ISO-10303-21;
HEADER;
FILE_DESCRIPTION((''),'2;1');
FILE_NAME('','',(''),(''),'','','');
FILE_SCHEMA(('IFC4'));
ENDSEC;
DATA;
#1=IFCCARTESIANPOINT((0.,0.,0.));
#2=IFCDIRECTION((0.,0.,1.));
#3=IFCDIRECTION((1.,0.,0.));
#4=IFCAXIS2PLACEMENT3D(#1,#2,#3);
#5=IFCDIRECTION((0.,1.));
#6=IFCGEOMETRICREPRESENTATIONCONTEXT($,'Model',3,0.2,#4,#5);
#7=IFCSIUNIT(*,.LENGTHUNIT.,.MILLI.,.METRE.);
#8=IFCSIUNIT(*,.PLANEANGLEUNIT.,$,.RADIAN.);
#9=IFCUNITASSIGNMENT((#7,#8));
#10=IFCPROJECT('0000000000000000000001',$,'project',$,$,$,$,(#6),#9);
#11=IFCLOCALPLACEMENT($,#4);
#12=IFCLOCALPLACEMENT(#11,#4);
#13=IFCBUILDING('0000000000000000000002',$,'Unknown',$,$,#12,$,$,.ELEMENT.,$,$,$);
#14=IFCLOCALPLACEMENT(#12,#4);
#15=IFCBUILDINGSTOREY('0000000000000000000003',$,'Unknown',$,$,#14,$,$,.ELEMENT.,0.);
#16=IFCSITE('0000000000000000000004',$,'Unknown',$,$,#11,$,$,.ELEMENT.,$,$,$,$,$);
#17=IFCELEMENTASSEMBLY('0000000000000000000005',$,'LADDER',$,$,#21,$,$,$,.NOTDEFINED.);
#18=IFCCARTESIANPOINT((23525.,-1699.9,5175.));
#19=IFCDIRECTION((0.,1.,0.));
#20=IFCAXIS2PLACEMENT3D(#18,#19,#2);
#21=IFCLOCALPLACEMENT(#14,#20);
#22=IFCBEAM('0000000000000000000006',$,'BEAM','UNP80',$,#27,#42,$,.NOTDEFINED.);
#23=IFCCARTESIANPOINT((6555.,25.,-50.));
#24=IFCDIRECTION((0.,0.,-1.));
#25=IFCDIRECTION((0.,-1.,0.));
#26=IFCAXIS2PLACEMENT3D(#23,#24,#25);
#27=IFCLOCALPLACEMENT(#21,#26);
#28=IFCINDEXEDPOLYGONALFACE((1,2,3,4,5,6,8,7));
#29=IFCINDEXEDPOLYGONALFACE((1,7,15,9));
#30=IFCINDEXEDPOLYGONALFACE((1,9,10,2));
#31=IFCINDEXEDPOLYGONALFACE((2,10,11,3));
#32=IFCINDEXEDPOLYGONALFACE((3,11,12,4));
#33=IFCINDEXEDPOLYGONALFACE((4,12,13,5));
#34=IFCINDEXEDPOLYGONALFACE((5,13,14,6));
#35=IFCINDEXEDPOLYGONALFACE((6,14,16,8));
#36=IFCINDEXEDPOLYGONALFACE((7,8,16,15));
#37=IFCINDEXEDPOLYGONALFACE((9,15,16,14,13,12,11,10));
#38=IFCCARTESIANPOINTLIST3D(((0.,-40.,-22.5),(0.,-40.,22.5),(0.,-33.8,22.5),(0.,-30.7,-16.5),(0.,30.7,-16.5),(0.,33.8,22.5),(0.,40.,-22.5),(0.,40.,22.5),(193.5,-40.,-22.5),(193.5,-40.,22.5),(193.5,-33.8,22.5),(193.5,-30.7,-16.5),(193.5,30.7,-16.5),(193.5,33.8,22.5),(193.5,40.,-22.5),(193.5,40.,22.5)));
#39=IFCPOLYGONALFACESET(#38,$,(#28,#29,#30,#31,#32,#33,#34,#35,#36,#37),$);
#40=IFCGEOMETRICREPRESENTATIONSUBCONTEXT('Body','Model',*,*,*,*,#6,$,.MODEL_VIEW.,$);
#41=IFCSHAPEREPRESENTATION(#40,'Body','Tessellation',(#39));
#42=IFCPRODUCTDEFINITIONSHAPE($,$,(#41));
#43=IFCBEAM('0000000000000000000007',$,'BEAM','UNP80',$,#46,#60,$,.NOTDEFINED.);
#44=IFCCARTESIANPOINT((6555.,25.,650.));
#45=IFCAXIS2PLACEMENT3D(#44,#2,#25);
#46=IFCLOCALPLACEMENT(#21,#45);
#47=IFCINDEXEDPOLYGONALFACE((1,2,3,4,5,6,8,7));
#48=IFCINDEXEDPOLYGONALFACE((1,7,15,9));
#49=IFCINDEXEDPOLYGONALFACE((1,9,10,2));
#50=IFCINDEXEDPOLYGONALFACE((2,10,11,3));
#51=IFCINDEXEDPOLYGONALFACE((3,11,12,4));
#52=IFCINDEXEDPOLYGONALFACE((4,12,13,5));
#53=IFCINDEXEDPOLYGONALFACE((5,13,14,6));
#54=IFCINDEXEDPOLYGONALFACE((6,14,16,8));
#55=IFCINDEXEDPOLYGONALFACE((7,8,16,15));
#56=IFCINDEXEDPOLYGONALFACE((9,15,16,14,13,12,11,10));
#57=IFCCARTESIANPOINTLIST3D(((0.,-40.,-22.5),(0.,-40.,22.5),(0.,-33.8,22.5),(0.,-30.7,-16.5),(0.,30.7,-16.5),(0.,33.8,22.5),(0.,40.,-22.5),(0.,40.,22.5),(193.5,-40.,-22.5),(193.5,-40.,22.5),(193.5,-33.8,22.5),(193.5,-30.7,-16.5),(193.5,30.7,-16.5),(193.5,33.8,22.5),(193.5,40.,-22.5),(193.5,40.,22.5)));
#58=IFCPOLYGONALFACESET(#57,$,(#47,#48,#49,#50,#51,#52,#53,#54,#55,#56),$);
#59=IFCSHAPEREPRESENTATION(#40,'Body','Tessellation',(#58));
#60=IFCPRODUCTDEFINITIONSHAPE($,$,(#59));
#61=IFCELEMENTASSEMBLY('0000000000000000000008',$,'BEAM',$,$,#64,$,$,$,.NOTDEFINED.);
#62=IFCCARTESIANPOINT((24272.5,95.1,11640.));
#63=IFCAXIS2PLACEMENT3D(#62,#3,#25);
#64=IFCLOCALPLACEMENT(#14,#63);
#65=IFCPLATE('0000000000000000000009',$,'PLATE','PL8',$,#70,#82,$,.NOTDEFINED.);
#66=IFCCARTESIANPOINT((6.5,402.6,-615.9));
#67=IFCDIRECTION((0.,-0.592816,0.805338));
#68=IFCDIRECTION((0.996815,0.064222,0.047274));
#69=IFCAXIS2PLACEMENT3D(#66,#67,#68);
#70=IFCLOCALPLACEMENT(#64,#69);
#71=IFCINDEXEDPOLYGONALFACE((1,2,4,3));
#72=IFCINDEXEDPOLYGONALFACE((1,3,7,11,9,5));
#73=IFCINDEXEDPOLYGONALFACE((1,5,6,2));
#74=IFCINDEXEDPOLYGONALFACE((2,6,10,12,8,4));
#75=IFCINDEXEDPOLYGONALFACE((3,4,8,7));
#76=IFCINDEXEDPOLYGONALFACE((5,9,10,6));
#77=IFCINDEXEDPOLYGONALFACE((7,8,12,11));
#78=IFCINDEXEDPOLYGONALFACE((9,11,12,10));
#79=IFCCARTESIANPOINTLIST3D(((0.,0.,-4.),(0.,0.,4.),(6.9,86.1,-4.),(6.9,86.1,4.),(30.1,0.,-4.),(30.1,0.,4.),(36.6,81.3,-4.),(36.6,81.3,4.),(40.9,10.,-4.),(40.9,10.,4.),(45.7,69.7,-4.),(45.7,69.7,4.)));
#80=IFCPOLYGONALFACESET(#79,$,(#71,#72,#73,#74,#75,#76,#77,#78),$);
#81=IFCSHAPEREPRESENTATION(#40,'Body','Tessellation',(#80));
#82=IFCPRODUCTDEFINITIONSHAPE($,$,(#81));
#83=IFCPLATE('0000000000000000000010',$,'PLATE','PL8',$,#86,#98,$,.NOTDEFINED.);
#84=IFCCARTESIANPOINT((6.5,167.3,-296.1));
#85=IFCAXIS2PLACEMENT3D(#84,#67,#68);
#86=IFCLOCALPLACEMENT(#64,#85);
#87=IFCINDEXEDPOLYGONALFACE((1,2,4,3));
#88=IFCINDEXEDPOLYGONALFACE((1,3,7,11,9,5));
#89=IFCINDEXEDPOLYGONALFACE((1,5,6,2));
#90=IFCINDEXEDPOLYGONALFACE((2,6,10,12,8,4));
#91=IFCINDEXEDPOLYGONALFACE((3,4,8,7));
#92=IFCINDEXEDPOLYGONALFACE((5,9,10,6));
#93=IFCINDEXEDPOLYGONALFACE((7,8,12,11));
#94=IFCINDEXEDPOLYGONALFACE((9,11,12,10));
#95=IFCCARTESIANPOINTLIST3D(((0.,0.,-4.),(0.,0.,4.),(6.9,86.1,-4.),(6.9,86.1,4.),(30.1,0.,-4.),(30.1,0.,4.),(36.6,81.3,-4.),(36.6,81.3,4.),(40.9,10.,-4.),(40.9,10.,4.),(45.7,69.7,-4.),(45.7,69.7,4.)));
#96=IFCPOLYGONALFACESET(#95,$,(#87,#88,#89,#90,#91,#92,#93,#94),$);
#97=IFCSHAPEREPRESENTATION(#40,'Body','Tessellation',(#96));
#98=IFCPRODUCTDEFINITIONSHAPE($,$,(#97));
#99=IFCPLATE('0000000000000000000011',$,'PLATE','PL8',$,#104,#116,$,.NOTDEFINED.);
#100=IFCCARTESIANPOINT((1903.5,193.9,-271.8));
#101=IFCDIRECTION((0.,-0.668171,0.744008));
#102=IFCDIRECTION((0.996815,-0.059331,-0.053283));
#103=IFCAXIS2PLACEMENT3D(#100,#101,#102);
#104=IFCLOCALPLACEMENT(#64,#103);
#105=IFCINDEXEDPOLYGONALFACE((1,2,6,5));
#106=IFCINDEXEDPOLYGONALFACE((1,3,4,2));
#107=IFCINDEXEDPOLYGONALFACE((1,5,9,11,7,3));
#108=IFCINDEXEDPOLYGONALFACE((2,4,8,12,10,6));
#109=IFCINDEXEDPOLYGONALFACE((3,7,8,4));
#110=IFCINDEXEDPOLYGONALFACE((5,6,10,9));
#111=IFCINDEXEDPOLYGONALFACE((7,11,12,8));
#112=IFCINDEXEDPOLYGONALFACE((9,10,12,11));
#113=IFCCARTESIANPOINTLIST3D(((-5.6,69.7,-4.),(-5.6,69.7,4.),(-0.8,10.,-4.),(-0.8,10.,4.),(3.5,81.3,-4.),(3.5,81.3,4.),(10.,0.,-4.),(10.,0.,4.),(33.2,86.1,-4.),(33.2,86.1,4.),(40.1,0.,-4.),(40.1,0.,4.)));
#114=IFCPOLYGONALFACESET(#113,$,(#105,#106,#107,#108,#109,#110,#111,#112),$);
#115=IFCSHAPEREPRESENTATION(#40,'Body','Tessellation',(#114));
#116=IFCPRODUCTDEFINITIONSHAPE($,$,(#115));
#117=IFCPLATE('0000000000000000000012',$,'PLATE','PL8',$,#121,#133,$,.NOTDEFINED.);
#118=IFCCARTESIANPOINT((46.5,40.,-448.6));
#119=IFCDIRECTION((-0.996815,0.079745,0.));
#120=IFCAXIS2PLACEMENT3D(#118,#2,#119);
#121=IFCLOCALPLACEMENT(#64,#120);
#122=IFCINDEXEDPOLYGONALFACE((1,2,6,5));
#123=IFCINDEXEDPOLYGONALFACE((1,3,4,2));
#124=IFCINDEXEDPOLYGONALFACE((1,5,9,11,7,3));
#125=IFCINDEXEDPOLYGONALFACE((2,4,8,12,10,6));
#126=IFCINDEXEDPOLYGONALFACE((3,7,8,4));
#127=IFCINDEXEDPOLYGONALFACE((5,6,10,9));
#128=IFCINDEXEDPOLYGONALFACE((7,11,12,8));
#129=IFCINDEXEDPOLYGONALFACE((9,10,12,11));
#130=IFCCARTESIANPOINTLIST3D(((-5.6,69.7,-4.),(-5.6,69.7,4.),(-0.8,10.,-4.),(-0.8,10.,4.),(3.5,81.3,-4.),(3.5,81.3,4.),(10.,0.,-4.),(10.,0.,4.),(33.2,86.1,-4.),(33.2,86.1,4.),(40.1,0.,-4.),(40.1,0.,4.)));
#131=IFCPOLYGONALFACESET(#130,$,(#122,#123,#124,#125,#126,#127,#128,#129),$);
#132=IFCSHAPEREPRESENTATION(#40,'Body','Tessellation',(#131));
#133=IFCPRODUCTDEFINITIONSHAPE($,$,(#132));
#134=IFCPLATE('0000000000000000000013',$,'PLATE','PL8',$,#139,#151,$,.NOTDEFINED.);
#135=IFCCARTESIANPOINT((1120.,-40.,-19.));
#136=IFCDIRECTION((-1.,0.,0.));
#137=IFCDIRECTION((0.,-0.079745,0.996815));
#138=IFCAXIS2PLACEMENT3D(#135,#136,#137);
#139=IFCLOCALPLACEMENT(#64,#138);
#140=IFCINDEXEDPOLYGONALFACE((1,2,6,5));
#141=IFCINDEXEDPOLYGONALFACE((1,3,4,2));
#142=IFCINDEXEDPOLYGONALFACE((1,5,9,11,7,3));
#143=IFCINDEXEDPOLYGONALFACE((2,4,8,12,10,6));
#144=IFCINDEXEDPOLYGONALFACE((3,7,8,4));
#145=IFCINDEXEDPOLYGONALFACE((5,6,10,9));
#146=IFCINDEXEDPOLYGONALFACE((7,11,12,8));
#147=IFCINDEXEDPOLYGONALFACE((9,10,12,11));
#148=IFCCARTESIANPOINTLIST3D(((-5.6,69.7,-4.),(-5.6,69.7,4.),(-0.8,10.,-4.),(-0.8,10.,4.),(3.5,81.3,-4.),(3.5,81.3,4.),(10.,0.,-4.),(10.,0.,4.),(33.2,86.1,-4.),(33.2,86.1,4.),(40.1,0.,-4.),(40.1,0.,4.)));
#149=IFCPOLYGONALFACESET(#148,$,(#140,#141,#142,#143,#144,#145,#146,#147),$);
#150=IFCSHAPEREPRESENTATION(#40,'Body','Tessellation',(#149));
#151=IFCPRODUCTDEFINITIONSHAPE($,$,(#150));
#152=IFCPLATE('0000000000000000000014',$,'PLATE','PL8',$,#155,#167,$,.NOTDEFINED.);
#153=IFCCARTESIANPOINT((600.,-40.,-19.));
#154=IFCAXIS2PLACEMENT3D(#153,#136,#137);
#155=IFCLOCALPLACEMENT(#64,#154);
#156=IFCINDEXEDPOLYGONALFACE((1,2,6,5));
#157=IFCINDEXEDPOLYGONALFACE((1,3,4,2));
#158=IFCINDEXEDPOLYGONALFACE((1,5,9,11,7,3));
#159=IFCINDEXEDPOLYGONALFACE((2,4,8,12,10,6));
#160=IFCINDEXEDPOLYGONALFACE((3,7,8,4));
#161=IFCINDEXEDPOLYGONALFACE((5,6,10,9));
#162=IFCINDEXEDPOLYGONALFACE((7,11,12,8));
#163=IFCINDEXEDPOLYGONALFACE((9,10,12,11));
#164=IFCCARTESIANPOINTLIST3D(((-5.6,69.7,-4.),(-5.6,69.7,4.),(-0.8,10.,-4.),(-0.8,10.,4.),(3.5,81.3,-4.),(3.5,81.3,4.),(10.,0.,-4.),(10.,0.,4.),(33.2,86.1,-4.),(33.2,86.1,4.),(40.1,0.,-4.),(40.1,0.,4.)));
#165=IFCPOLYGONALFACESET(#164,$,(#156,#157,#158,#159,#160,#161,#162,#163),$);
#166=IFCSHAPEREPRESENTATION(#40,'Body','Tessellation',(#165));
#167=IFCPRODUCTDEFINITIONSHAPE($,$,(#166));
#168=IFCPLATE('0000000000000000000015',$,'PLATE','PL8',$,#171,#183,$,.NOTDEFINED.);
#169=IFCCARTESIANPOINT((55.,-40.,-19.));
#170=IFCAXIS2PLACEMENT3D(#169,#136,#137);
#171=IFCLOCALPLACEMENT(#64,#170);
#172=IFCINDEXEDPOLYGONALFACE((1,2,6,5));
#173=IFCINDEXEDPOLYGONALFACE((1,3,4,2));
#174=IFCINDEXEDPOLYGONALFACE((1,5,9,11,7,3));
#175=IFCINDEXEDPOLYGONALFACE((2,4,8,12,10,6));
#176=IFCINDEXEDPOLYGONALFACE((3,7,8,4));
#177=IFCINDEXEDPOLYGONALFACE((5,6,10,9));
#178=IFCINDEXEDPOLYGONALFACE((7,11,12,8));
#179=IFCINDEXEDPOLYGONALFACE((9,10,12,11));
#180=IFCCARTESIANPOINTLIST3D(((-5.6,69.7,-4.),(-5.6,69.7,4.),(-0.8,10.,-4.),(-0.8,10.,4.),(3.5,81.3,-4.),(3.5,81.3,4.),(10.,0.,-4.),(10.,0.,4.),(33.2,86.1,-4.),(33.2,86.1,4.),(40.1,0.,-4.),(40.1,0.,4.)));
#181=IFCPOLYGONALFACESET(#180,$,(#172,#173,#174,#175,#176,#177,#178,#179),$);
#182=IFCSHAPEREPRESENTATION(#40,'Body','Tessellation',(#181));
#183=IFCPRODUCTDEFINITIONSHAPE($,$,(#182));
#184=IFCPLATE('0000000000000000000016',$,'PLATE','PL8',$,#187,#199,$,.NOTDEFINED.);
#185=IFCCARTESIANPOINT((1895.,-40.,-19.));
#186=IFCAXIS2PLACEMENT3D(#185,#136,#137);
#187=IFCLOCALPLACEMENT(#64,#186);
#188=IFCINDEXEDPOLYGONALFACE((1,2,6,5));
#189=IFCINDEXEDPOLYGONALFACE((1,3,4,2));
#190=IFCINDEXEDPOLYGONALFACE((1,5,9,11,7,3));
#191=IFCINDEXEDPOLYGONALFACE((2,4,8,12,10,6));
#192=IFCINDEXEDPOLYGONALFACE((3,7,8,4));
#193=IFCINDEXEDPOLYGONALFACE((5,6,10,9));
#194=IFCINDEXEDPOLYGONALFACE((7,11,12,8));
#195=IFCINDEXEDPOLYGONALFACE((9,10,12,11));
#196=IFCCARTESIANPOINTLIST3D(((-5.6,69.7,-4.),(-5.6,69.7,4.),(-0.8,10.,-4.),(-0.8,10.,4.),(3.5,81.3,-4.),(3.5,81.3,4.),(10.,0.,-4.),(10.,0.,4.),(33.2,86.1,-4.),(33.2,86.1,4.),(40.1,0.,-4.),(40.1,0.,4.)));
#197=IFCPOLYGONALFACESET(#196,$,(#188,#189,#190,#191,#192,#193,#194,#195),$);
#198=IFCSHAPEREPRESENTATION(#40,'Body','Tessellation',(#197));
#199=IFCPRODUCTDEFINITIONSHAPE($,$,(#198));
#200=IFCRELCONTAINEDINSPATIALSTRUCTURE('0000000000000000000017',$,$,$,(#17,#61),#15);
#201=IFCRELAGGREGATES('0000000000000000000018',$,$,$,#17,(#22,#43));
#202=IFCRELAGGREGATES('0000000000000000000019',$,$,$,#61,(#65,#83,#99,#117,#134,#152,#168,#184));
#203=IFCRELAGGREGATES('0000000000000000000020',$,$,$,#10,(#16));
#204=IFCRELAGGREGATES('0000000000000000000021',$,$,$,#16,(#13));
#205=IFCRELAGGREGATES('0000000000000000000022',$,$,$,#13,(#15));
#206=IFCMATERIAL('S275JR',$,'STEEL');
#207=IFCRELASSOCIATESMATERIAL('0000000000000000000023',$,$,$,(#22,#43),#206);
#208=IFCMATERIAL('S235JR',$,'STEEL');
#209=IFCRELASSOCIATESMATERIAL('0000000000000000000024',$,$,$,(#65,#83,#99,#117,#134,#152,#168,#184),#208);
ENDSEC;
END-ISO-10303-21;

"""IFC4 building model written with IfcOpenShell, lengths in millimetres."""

from ifc_helpers import new_model, si_unit, direction, frame, origin_with_axes, place, context, subcontext, project, spatial, line, indexed_curve, outline, extrude, material, element, aggregate, save


model = new_model("IFC4")

# Units and contexts
model_context = context("Model", 3, precision=0.2, world=origin_with_axes(), true_north=direction((0.0, 1.0)))
body_context = subcontext(model_context, "Body", "Model", "MODEL_VIEW")
ifc_project = project(units=[si_unit("LENGTHUNIT", "METRE", prefix="MILLI"), si_unit("PLANEANGLEUNIT", "RADIAN")], contexts=[model_context])

# Site, building, storey
site_placement = place(None, origin_with_axes())
site = spatial("IfcSite", under=ifc_project, at=site_placement, Name="Unknown", CompositionType="ELEMENT")
building_placement = place(site_placement, origin_with_axes())
building = spatial("IfcBuilding", under=site, at=building_placement, Name="Unknown", CompositionType="ELEMENT")
storey_placement = place(building_placement, origin_with_axes())
storey = spatial("IfcBuildingStorey", under=building, at=storey_placement, Name="Unknown", CompositionType="ELEMENT", Elevation=0.0)

# Element assembly, beams
assembly_1_placement = place(storey_placement, frame((23525.0, -1699.9, 5175.0), z_axis=(0.0, 1.0, 0.0), x_axis=(0.0, 0.0, 1.0)))
assembly_1 = element("IfcElementAssembly", 1, at=assembly_1_placement, inside=storey, Name="LADDER", PredefinedType="NOTDEFINED")
ifc_material_1 = material(Name="S235JR", Category="STEEL")
ifc_material_2 = material(Name="S275JR", Category="STEEL")
beam_1_placement = place(assembly_1_placement, frame((6555.0, 25.0, -50.0), z_axis=(0.0, 0.0, -1.0), x_axis=(0.0, -1.0, 0.0)))
beam_1 = element("IfcBeam", 2, at=beam_1_placement, material=ifc_material_2, Name="BEAM", Description="UNP80", PredefinedType="NOTDEFINED", context=body_context, shape_type="SolidModel", body=[
    extrude(outline(indexed_curve([(-22.5, -40.0), (22.5, -40.0), (22.5, -33.8), (-16.5, -30.7), (-16.5, 30.7), (22.5, 33.8), (22.5, 40.0), (-22.5, 40.0)], segments=[line(1, 2, 3, 4, 5, 6, 7, 8, 1)])), frame((0.0, 0.0, 0.0), z_axis=(-1.0, 0.0, 0.0), x_axis=(0.0, 0.0, 1.0)), (0.0, 0.0, -1.0), 193.5),
])
beam_2_placement = place(assembly_1_placement, frame((6555.0, 25.0, 650.0), z_axis=(0.0, 0.0, 1.0), x_axis=(0.0, -1.0, 0.0)))
beam_2 = element("IfcBeam", 3, at=beam_2_placement, material=ifc_material_2, Name="BEAM", Description="UNP80", PredefinedType="NOTDEFINED", context=body_context, shape_type="SolidModel", body=[
    extrude(outline(indexed_curve([(-22.5, -40.0), (22.5, -40.0), (22.5, -33.8), (-16.5, -30.7), (-16.5, 30.7), (22.5, 33.8), (22.5, 40.0), (-22.5, 40.0)], segments=[line(1, 2, 3, 4, 5, 6, 7, 8, 1)])), frame((0.0, 0.0, 0.0), z_axis=(-1.0, 0.0, 0.0), x_axis=(0.0, 0.0, 1.0)), (0.0, 0.0, -1.0), 193.5),
])

# Element assembly
assembly_2_placement = place(storey_placement, frame((24272.5, 95.1, 11640.0), z_axis=(1.0, 0.0, 0.0), x_axis=(0.0, -1.0, 0.0)))
assembly_2 = element("IfcElementAssembly", 4, at=assembly_2_placement, inside=storey, Name="BEAM", PredefinedType="NOTDEFINED")

# Plates
aggregate(assembly_1, [beam_1, beam_2])
plate_1_placement = place(assembly_2_placement, frame((6.5, 402.6, -615.9), z_axis=(0.0, -0.592816, 0.805338), x_axis=(0.996815, 0.064222, 0.047274)))
plate_1 = element("IfcPlate", 5, at=plate_1_placement, material=ifc_material_1, Name="PLATE", Description="PL8", PredefinedType="NOTDEFINED", context=body_context, shape_type="SolidModel", body=[
    extrude(outline(indexed_curve([(0.0, 0.0), (30.1, 0.0), (40.9, 10.0), (45.7, 69.7), (36.6, 81.3), (6.9, 86.1)], segments=[line(1, 2, 3, 4, 5, 6, 1)])), frame((0.0, 0.0, 4.0), z_axis=(0.0, 0.0, 1.0), x_axis=(1.0, 0.0, 0.0)), (0.0, 0.0, -1.0), 8.0),
])
plate_2_placement = place(assembly_2_placement, frame((6.5, 167.3, -296.1), z_axis=(0.0, -0.592816, 0.805338), x_axis=(0.996815, 0.064222, 0.047274)))
plate_2 = element("IfcPlate", 6, at=plate_2_placement, material=ifc_material_1, Name="PLATE", Description="PL8", PredefinedType="NOTDEFINED", context=body_context, shape_type="SolidModel", body=[
    extrude(outline(indexed_curve([(0.0, 0.0), (30.1, 0.0), (40.9, 10.0), (45.7, 69.7), (36.6, 81.3), (6.9, 86.1)], segments=[line(1, 2, 3, 4, 5, 6, 1)])), frame((0.0, 0.0, 4.0), z_axis=(0.0, 0.0, 1.0), x_axis=(1.0, 0.0, 0.0)), (0.0, 0.0, -1.0), 8.0),
])
plate_3_placement = place(assembly_2_placement, frame((1903.5, 193.9, -271.8), z_axis=(0.0, -0.668171, 0.744008), x_axis=(0.996815, -0.059331, -0.053283)))
plate_3 = element("IfcPlate", 7, at=plate_3_placement, material=ifc_material_1, Name="PLATE", Description="PL8", PredefinedType="NOTDEFINED", context=body_context, shape_type="SolidModel", body=[
    extrude(outline(indexed_curve([(-0.8, 10.0), (10.0, 0.0), (40.1, 0.0), (33.2, 86.1), (3.5, 81.3), (-5.6, 69.7)], segments=[line(1, 2, 3, 4, 5, 6, 1)])), frame((0.0, 0.0, 4.0), z_axis=(0.0, 0.0, 1.0), x_axis=(1.0, 0.0, 0.0)), (0.0, 0.0, -1.0), 8.0),
])
plate_4_placement = place(assembly_2_placement, frame((46.5, 40.0, -448.6), z_axis=(0.0, 0.0, 1.0), x_axis=(-0.996815, 0.079745, 0.0)))
plate_4 = element("IfcPlate", 8, at=plate_4_placement, material=ifc_material_1, Name="PLATE", Description="PL8", PredefinedType="NOTDEFINED", context=body_context, shape_type="SolidModel", body=[
    extrude(outline(indexed_curve([(-0.8, 10.0), (10.0, 0.0), (40.1, 0.0), (33.2, 86.1), (3.5, 81.3), (-5.6, 69.7)], segments=[line(1, 2, 3, 4, 5, 6, 1)])), frame((0.0, 0.0, 4.0), z_axis=(0.0, 0.0, 1.0), x_axis=(1.0, 0.0, 0.0)), (0.0, 0.0, -1.0), 8.0),
])
plate_5_placement = place(assembly_2_placement, frame((1120.0, -40.0, -19.0), z_axis=(-1.0, 0.0, 0.0), x_axis=(0.0, -0.079745, 0.996815)))
plate_5 = element("IfcPlate", 9, at=plate_5_placement, material=ifc_material_1, Name="PLATE", Description="PL8", PredefinedType="NOTDEFINED", context=body_context, shape_type="SolidModel", body=[
    extrude(outline(indexed_curve([(-0.8, 10.0), (10.0, 0.0), (40.1, 0.0), (33.2, 86.1), (3.5, 81.3), (-5.6, 69.7)], segments=[line(1, 2, 3, 4, 5, 6, 1)])), frame((0.0, 0.0, 4.0), z_axis=(0.0, 0.0, 1.0), x_axis=(1.0, 0.0, 0.0)), (0.0, 0.0, -1.0), 8.0),
])
plate_6_placement = place(assembly_2_placement, frame((600.0, -40.0, -19.0), z_axis=(-1.0, 0.0, 0.0), x_axis=(0.0, -0.079745, 0.996815)))
plate_6 = element("IfcPlate", 10, at=plate_6_placement, material=ifc_material_1, Name="PLATE", Description="PL8", PredefinedType="NOTDEFINED", context=body_context, shape_type="SolidModel", body=[
    extrude(outline(indexed_curve([(-0.8, 10.0), (10.0, 0.0), (40.1, 0.0), (33.2, 86.1), (3.5, 81.3), (-5.6, 69.7)], segments=[line(1, 2, 3, 4, 5, 6, 1)])), frame((0.0, 0.0, 4.0), z_axis=(0.0, 0.0, 1.0), x_axis=(1.0, 0.0, 0.0)), (0.0, 0.0, -1.0), 8.0),
])
plate_7_placement = place(assembly_2_placement, frame((55.0, -40.0, -19.0), z_axis=(-1.0, 0.0, 0.0), x_axis=(0.0, -0.079745, 0.996815)))
plate_7 = element("IfcPlate", 11, at=plate_7_placement, material=ifc_material_1, Name="PLATE", Description="PL8", PredefinedType="NOTDEFINED", context=body_context, shape_type="SolidModel", body=[
    extrude(outline(indexed_curve([(-0.8, 10.0), (10.0, 0.0), (40.1, 0.0), (33.2, 86.1), (3.5, 81.3), (-5.6, 69.7)], segments=[line(1, 2, 3, 4, 5, 6, 1)])), frame((0.0, 0.0, 4.0), z_axis=(0.0, 0.0, 1.0), x_axis=(1.0, 0.0, 0.0)), (0.0, 0.0, -1.0), 8.0),
])
plate_8_placement = place(assembly_2_placement, frame((1895.0, -40.0, -19.0), z_axis=(-1.0, 0.0, 0.0), x_axis=(0.0, -0.079745, 0.996815)))
plate_8 = element("IfcPlate", 12, at=plate_8_placement, material=ifc_material_1, Name="PLATE", Description="PL8", PredefinedType="NOTDEFINED", context=body_context, shape_type="SolidModel", body=[
    extrude(outline(indexed_curve([(-0.8, 10.0), (10.0, 0.0), (40.1, 0.0), (33.2, 86.1), (3.5, 81.3), (-5.6, 69.7)], segments=[line(1, 2, 3, 4, 5, 6, 1)])), frame((0.0, 0.0, 4.0), z_axis=(0.0, 0.0, 1.0), x_axis=(1.0, 0.0, 0.0)), (0.0, 0.0, -1.0), 8.0),
])
aggregate(assembly_2, [plate_1, plate_2, plate_3, plate_4, plate_5, plate_6, plate_7, plate_8])

save(model, "model.ifc")
